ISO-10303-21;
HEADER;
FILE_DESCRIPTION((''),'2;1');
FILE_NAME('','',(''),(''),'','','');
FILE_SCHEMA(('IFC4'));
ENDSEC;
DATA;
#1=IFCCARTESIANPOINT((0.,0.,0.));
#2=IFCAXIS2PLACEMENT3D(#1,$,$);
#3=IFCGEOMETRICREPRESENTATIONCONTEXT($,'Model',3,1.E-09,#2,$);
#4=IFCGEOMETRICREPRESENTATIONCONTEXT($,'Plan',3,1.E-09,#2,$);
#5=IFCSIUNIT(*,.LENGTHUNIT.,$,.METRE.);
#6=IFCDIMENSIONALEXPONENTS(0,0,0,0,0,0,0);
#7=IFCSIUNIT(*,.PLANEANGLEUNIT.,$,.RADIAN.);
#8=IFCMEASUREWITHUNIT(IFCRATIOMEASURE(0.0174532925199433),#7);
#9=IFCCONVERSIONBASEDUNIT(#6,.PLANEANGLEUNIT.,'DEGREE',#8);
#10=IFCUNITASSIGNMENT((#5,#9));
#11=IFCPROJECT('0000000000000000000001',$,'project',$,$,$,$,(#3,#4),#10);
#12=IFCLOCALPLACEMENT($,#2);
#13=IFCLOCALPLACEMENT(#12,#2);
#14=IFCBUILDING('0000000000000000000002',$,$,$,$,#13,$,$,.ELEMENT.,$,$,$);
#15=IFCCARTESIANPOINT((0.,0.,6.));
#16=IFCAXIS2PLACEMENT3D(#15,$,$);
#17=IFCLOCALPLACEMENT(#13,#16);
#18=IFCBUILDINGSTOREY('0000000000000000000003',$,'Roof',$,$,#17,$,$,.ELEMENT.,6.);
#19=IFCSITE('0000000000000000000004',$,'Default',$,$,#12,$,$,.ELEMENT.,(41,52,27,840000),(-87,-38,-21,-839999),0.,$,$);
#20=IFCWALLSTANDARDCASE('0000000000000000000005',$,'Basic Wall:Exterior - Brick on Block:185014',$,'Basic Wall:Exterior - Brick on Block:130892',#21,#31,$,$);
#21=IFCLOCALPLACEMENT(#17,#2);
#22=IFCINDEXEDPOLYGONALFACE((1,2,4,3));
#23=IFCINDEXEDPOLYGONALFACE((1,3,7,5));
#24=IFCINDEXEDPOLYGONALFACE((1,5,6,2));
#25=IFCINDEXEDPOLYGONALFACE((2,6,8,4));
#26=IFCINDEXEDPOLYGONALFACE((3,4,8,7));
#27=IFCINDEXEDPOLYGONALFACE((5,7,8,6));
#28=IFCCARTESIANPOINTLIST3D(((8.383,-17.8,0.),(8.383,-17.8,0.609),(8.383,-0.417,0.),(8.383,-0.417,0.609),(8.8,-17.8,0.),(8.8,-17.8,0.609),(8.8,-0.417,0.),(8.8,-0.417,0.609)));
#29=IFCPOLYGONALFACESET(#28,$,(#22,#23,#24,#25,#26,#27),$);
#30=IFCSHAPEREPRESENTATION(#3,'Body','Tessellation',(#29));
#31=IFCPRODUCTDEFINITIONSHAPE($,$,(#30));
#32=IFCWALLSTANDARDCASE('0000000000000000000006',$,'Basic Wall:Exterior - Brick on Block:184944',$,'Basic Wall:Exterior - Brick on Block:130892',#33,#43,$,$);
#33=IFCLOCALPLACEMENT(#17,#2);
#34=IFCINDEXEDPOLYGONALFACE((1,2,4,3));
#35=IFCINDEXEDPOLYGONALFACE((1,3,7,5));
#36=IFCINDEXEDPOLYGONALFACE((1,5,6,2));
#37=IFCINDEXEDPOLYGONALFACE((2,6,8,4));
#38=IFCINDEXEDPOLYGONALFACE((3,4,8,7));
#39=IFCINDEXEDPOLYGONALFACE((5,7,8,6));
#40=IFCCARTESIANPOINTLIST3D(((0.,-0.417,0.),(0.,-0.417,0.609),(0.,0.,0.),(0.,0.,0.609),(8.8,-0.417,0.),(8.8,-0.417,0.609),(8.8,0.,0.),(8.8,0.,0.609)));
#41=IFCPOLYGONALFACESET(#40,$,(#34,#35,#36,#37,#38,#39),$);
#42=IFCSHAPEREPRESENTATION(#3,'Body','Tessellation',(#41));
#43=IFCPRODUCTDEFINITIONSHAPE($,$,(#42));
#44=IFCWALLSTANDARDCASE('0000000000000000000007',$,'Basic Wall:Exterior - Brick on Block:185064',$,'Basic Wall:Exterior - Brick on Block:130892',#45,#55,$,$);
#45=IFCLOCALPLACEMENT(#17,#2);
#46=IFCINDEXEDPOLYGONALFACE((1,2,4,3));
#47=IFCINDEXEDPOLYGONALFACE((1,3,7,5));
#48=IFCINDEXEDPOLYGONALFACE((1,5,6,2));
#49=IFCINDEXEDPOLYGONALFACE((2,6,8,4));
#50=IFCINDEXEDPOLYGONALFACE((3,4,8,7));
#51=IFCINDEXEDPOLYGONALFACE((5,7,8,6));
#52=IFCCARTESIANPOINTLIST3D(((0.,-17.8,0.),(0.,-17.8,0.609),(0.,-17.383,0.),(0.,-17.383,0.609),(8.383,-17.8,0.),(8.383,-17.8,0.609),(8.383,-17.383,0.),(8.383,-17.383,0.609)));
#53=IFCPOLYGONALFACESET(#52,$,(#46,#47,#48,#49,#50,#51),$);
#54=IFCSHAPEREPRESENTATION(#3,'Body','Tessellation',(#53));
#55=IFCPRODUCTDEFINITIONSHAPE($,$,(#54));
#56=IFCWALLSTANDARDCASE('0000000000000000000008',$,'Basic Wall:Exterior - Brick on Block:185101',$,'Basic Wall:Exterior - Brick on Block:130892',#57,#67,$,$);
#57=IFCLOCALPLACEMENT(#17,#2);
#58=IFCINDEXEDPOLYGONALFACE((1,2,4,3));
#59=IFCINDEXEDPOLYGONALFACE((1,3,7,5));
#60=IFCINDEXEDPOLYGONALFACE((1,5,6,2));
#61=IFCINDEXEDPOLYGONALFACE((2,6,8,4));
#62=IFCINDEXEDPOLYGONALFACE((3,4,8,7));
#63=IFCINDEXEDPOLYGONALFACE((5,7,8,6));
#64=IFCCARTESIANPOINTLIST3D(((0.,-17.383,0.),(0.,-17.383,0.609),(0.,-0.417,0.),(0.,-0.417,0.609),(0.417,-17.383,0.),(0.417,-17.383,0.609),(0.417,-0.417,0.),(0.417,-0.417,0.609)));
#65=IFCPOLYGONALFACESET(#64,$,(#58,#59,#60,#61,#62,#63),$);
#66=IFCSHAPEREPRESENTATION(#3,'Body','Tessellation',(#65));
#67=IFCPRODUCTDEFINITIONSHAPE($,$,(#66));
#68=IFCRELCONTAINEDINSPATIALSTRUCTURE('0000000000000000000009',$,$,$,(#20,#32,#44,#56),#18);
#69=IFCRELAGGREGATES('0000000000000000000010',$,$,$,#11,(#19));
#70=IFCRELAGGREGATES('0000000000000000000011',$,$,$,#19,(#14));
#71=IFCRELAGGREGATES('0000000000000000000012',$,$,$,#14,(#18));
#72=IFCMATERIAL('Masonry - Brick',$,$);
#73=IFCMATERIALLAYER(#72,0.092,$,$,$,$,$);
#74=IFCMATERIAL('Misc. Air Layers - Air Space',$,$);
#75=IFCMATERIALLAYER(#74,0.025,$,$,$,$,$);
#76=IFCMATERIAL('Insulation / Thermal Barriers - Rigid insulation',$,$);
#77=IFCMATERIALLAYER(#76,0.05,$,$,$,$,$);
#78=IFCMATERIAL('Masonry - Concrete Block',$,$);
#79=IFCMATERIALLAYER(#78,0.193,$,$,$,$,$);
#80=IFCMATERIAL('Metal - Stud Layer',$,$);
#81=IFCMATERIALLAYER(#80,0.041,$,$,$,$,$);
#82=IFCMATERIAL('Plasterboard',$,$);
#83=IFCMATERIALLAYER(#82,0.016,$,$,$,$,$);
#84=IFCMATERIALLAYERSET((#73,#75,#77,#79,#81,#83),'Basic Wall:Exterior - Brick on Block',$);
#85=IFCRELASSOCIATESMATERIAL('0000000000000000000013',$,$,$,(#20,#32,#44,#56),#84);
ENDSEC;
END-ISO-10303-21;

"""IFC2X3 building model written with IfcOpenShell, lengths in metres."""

from ifc_helpers import new_model, entity, si_unit, converted_unit, frame, frame_2d, origin, place, context, project, spatial, rectangle, extrude, material, layer, layer_set, layer_usage, element, save


model = new_model("IFC2X3")

# Units and contexts
model_context = context("Model", 3, precision=1e-09, world=origin())
plan_context = context("Plan", 3, precision=1e-09, world=origin())
ifc_project = project(units=[si_unit("LENGTHUNIT", "METRE"), converted_unit("PLANEANGLEUNIT", "DEGREE", entity("IfcRatioMeasure", 0.0174532925199433), si_unit("PLANEANGLEUNIT", "RADIAN"), dimensions=[0, 0, 0, 0, 0, 0, 0])], contexts=[model_context, plan_context])

# Site, building, storey
site_placement = place(None, origin())
site = spatial("IfcSite", under=ifc_project, at=site_placement, Name="Default", CompositionType="ELEMENT", RefLatitude=(41, 52, 27, 840000), RefLongitude=(-87, -38, -21, -839999), RefElevation=0.0)
building_placement = place(site_placement, origin())
building = spatial("IfcBuilding", under=site, at=building_placement, CompositionType="ELEMENT")
storey_placement = place(building_placement, frame((0.0, 0.0, 6.0)))
storey = spatial("IfcBuildingStorey", under=building, at=storey_placement, Name="Roof", CompositionType="ELEMENT", Elevation=6.0)

# Walls
ifc_material_1 = material(Name="Masonry - Brick")
ifc_layer_1 = layer(ifc_material_1, 0.092)
ifc_material_2 = material(Name="Misc. Air Layers - Air Space")
ifc_layer_2 = layer(ifc_material_2, 0.025)
ifc_material_3 = material(Name="Insulation / Thermal Barriers - Rigid insulation")
ifc_layer_3 = layer(ifc_material_3, 0.05)
ifc_material_4 = material(Name="Masonry - Concrete Block")
ifc_layer_4 = layer(ifc_material_4, 0.193)
ifc_material_5 = material(Name="Metal - Stud Layer")
ifc_layer_5 = layer(ifc_material_5, 0.041)
ifc_material_6 = material(Name="Plasterboard")
ifc_layer_6 = layer(ifc_material_6, 0.016)
ifc_layer_set = layer_set([ifc_layer_1, ifc_layer_2, ifc_layer_3, ifc_layer_4, ifc_layer_5, ifc_layer_6], Name="Basic Wall:Exterior - Brick on Block")
ifc_layer_usage = layer_usage(ifc_layer_set, "AXIS2", "NEGATIVE", 0.2085)
wall_1_placement = place(storey_placement, frame((8.5915, -0.417, 0.0), z_axis=(0.0, 0.0, 1.0), x_axis=(0.0, -1.0, 0.0)))
element("IfcWallStandardCase", 1, at=wall_1_placement, inside=storey, material=ifc_layer_usage, Name="Basic Wall:Exterior - Brick on Block:185014", ObjectType="Basic Wall:Exterior - Brick on Block:130892", context=model_context, shape_type="SweptSolid", body=[
    extrude(rectangle(XDim=17.383, YDim=0.417, at=frame_2d((8.6915, 0.0), x_axis=(-1.0, 0.0))), origin(), (0.0, 0.0, 1.0), 0.609),
])
wall_2_placement = place(storey_placement, frame((0.0, -0.2085, 0.0)))
element("IfcWallStandardCase", 2, at=wall_2_placement, inside=storey, material=ifc_layer_usage, Name="Basic Wall:Exterior - Brick on Block:184944", ObjectType="Basic Wall:Exterior - Brick on Block:130892", context=model_context, shape_type="SweptSolid", body=[
    extrude(rectangle(XDim=8.8, YDim=0.417, at=frame_2d((4.4, 0.0), x_axis=(-1.0, 0.0))), origin(), (0.0, 0.0, 1.0), 0.609),
])
wall_3_placement = place(storey_placement, frame((8.383, -17.5915, 0.0), z_axis=(0.0, 0.0, 1.0), x_axis=(-1.0, 0.0, 0.0)))
element("IfcWallStandardCase", 3, at=wall_3_placement, inside=storey, material=ifc_layer_usage, Name="Basic Wall:Exterior - Brick on Block:185064", ObjectType="Basic Wall:Exterior - Brick on Block:130892", context=model_context, shape_type="SweptSolid", body=[
    extrude(rectangle(XDim=8.383, YDim=0.417, at=frame_2d((4.1915, 0.0), x_axis=(-1.0, 0.0))), origin(), (0.0, 0.0, 1.0), 0.609),
])
wall_4_placement = place(storey_placement, frame((0.2085, -17.383, 0.0), z_axis=(0.0, 0.0, 1.0), x_axis=(0.0, 1.0, 0.0)))
element("IfcWallStandardCase", 4, at=wall_4_placement, inside=storey, material=ifc_layer_usage, Name="Basic Wall:Exterior - Brick on Block:185101", ObjectType="Basic Wall:Exterior - Brick on Block:130892", context=model_context, shape_type="SweptSolid", body=[
    extrude(rectangle(XDim=16.966, YDim=0.417, at=frame_2d((8.483, 0.0), x_axis=(-1.0, 0.0))), origin(), (0.0, 0.0, 1.0), 0.609),
])

save(model, "model.ifc")
